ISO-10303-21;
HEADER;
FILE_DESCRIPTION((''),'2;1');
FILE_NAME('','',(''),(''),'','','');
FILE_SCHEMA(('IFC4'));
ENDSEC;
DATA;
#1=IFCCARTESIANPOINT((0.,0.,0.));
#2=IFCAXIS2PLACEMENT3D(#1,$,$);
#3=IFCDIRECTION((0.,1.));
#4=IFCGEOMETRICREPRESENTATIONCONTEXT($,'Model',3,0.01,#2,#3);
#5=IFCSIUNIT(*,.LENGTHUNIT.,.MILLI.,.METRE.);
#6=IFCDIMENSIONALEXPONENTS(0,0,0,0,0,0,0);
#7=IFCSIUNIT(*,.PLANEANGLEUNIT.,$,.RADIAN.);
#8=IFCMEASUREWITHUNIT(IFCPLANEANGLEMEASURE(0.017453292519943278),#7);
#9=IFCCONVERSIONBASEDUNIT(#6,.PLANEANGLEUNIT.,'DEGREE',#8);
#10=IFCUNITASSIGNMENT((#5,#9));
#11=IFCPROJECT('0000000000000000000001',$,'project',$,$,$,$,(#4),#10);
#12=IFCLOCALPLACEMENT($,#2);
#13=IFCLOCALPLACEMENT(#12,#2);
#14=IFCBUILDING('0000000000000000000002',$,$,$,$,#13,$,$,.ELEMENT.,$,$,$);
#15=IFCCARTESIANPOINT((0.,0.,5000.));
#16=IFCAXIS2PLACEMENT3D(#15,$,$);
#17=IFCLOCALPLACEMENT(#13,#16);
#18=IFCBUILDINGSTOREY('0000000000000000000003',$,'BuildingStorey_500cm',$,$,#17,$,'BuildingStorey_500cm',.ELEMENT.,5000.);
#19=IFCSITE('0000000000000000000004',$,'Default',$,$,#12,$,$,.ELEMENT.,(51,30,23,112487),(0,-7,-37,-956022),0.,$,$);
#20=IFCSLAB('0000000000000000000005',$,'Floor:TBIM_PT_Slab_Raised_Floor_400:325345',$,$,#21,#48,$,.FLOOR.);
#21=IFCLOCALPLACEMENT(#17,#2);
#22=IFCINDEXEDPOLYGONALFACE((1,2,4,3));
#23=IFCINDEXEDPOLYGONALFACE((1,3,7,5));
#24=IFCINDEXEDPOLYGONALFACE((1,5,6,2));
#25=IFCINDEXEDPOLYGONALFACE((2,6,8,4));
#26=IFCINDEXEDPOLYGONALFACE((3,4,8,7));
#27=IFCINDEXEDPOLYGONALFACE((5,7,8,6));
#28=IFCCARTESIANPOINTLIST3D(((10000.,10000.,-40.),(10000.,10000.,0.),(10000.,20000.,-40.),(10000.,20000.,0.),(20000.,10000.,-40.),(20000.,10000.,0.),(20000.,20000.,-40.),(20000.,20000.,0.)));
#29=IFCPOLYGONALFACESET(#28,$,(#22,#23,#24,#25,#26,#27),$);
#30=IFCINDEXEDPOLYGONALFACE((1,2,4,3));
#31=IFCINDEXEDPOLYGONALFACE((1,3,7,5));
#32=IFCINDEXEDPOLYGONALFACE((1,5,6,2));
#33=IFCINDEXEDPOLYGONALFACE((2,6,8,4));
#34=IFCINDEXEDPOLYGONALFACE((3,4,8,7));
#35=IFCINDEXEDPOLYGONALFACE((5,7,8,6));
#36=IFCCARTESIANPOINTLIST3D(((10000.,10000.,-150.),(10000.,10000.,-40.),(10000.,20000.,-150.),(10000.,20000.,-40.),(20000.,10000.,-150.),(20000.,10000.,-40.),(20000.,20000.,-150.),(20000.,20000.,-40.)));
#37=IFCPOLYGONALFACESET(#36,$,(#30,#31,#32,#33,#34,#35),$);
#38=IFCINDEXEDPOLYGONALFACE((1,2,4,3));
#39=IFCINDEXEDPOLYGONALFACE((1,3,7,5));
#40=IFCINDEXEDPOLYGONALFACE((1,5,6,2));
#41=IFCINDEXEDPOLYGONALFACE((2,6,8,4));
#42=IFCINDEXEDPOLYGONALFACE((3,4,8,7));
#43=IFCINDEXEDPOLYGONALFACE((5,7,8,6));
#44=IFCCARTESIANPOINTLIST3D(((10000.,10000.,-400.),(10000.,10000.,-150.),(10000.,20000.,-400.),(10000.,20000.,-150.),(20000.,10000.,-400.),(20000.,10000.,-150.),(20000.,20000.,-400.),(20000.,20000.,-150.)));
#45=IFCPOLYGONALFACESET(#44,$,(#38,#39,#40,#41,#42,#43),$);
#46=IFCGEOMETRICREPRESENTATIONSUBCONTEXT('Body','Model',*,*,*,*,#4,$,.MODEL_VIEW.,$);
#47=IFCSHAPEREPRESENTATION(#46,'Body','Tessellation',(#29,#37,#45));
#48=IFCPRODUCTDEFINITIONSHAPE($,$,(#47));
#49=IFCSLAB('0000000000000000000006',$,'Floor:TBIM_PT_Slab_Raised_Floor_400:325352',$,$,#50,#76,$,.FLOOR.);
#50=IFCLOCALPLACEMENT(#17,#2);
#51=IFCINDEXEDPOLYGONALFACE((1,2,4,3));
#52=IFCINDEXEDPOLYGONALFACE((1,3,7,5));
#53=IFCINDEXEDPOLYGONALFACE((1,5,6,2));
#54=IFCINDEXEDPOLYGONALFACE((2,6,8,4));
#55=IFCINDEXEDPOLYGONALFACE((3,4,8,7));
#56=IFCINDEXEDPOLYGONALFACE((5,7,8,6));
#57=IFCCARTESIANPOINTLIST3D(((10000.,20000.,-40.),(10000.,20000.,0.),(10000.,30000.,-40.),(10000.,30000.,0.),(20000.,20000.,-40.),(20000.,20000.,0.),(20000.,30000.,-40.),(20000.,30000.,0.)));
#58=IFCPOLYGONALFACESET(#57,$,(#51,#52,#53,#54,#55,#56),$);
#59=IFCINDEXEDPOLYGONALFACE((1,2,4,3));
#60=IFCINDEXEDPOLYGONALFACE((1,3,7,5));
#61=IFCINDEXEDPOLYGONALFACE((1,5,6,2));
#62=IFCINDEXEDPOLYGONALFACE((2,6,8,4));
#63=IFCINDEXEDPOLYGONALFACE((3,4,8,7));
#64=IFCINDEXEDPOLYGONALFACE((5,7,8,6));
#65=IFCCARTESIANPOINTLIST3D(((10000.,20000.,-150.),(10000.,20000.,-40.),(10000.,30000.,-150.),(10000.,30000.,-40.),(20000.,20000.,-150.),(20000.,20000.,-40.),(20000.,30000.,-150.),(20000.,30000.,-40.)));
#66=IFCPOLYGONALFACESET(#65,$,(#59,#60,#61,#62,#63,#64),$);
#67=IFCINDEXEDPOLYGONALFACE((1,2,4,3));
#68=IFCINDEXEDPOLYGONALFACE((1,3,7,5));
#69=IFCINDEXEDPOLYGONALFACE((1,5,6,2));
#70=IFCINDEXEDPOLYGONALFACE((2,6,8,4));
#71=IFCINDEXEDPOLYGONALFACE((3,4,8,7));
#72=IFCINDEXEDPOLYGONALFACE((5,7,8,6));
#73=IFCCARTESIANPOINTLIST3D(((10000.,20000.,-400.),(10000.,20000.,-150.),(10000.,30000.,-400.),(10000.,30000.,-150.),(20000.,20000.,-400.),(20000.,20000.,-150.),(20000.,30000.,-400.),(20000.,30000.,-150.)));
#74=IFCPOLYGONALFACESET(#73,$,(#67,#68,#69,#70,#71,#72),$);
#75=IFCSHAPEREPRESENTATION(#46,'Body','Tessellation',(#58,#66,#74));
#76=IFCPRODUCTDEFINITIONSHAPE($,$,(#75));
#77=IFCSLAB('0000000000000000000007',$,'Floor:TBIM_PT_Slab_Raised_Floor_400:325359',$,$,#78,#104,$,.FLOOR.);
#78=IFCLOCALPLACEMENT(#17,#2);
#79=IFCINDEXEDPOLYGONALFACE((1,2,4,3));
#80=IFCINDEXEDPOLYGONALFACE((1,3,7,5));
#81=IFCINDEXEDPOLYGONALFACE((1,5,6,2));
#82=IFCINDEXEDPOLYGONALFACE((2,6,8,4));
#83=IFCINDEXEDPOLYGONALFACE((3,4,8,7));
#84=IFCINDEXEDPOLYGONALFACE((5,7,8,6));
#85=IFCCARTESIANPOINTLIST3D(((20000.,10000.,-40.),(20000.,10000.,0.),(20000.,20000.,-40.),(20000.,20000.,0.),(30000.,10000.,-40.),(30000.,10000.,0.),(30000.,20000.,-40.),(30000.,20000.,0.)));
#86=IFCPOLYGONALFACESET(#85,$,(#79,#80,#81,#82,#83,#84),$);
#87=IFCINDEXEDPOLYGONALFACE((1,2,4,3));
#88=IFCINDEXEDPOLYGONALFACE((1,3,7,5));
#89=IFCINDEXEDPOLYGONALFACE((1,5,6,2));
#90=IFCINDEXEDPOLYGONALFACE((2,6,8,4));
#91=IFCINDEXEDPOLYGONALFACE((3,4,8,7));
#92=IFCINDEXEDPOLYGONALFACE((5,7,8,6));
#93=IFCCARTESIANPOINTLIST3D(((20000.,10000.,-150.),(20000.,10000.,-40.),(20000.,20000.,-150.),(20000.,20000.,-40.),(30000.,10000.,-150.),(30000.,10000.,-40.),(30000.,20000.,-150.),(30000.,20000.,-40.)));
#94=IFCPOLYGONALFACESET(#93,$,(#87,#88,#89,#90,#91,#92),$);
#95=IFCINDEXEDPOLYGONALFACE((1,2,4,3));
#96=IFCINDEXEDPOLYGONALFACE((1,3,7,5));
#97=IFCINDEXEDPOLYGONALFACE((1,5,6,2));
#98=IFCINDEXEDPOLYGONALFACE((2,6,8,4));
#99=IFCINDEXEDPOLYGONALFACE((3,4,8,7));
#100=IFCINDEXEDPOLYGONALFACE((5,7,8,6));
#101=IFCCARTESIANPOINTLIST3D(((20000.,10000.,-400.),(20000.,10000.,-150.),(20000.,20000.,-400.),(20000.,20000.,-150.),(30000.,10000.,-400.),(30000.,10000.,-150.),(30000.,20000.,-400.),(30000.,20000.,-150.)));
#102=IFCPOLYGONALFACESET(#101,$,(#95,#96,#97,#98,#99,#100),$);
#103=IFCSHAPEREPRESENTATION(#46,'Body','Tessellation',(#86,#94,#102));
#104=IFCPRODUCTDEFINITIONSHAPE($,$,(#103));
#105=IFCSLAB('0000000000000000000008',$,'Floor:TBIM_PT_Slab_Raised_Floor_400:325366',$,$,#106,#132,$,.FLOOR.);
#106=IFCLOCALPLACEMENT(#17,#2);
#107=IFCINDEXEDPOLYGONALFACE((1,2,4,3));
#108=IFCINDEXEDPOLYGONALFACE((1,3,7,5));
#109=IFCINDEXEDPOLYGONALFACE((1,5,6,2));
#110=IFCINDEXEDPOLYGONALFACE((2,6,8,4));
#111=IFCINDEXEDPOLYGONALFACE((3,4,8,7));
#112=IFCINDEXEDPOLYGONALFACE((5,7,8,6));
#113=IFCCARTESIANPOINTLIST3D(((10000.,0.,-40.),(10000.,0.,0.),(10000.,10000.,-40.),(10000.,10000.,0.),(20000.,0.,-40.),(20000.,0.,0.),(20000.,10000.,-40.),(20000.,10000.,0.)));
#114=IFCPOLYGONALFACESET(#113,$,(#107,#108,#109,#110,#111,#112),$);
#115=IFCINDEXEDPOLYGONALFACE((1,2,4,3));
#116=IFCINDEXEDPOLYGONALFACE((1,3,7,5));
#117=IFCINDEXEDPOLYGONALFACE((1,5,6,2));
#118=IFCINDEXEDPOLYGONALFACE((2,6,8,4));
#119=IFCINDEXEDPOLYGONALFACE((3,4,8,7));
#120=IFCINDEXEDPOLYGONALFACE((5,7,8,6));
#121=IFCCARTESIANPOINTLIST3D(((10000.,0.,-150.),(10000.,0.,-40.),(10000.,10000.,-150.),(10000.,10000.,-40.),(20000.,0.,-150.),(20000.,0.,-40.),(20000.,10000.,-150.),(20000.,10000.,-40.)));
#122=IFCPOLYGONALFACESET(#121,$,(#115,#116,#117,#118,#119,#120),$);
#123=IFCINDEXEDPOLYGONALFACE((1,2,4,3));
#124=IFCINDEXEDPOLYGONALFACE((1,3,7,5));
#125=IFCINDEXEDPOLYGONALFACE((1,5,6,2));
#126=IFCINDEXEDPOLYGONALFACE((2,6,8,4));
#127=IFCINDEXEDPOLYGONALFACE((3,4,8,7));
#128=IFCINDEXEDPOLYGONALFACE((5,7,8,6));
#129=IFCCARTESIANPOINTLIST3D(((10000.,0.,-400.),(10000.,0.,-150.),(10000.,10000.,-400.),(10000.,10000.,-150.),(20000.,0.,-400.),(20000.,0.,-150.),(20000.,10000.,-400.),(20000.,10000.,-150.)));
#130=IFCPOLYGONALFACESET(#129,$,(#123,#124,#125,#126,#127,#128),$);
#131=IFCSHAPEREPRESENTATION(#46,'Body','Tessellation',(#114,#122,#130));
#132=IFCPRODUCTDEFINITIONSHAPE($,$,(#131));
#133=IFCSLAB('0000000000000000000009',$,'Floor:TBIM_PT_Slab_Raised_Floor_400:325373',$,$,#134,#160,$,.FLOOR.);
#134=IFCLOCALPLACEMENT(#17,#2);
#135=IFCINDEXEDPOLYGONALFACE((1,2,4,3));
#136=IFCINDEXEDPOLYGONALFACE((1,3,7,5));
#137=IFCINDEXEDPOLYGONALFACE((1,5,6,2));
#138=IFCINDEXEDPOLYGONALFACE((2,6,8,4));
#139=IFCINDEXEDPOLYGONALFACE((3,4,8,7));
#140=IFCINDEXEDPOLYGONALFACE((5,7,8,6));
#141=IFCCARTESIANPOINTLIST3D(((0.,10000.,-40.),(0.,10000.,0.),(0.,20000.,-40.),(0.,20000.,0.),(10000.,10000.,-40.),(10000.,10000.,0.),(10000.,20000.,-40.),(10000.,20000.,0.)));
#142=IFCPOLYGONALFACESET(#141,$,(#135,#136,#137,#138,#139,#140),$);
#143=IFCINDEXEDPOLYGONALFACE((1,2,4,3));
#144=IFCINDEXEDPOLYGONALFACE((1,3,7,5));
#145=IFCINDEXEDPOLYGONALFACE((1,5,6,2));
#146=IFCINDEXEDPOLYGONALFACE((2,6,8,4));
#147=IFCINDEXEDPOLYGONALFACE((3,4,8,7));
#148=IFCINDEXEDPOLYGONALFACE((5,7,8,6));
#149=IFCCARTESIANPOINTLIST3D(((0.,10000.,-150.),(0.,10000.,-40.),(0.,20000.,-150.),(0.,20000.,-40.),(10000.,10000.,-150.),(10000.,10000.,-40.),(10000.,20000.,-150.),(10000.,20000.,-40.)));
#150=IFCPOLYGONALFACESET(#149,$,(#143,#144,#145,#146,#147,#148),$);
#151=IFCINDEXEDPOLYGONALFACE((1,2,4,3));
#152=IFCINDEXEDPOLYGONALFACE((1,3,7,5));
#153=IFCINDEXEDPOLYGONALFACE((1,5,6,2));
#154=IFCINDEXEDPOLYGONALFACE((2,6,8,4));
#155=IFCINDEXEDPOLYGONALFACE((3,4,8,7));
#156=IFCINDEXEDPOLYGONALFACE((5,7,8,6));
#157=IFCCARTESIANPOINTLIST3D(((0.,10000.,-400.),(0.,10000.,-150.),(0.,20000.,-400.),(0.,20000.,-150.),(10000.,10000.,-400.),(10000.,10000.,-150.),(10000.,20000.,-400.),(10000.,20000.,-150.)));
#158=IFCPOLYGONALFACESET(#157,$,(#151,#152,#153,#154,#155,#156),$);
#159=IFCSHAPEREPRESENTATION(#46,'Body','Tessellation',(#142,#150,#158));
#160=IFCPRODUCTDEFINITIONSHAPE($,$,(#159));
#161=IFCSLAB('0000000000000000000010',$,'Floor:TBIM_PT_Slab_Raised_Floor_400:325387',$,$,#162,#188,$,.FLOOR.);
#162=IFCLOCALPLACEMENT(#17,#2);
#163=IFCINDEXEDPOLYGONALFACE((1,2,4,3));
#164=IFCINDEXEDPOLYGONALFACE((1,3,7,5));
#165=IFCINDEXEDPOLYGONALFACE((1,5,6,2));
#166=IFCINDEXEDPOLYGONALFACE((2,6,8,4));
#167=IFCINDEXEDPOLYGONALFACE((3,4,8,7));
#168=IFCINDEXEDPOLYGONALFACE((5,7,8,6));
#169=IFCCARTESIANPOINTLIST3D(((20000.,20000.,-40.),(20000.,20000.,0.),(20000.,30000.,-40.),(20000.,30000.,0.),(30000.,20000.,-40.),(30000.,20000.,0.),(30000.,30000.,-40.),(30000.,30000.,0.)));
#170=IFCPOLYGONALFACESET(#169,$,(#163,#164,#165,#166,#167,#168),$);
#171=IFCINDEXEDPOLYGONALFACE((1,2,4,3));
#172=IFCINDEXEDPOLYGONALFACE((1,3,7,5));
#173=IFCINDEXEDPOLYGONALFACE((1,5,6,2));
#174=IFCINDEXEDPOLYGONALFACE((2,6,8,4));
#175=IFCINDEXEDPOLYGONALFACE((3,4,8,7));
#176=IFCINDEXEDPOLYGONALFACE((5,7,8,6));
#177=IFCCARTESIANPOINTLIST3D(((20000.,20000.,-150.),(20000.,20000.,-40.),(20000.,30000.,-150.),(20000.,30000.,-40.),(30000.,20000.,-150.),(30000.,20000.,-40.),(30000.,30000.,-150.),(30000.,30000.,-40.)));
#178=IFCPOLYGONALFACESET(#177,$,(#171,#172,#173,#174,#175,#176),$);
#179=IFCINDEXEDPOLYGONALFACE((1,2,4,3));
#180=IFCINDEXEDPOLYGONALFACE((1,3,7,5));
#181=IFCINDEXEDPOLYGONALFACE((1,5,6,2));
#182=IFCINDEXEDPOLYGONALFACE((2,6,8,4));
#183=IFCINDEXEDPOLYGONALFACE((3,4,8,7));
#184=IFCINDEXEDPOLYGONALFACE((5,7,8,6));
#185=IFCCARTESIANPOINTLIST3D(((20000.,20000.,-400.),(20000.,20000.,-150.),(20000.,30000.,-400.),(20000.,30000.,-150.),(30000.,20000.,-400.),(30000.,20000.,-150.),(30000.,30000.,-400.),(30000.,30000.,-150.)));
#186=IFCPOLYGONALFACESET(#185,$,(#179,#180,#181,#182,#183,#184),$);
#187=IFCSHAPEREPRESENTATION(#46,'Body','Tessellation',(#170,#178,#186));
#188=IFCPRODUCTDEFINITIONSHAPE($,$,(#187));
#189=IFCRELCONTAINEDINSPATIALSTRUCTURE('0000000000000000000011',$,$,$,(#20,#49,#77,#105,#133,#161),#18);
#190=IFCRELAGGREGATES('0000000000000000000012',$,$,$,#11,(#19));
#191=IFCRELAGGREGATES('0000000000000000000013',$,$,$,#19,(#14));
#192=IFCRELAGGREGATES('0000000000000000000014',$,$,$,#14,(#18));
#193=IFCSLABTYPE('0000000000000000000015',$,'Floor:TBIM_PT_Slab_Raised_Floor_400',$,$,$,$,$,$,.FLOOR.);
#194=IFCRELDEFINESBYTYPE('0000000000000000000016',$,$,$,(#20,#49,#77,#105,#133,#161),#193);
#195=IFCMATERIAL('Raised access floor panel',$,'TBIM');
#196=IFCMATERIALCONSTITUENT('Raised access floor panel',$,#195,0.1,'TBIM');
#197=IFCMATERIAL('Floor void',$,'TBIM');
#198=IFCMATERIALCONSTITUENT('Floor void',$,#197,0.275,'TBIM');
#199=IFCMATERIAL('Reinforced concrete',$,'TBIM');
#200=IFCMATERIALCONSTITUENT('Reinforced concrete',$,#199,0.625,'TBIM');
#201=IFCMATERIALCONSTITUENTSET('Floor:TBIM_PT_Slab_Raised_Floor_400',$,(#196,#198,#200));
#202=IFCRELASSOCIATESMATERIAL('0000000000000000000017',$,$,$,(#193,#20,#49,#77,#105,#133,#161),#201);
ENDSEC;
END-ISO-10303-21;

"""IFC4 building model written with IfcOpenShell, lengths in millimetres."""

from ifc_helpers import new_model, entity, si_unit, converted_unit, direction, frame, origin, place, context, subcontext, project, spatial, indexed_curve, outline, extrude, material, constituent, constituent_set, type_object, element, save


model = new_model("IFC4")

# Units and contexts
model_context = context("Model", 3, precision=0.01, world=origin(), true_north=direction((0.0, 1.0)))
body_context = subcontext(model_context, "Body", "Model", "MODEL_VIEW")
ifc_project = project(units=[si_unit("LENGTHUNIT", "METRE", prefix="MILLI"), converted_unit("PLANEANGLEUNIT", "DEGREE", entity("IfcPlaneAngleMeasure", 0.017453292519943278), si_unit("PLANEANGLEUNIT", "RADIAN"), dimensions=[0, 0, 0, 0, 0, 0, 0])], contexts=[model_context])

# Site, building, storey
site_placement = place(None, origin())
site = spatial("IfcSite", under=ifc_project, at=site_placement, Name="Default", CompositionType="ELEMENT", RefLatitude=(51, 30, 23, 112487), RefLongitude=(0, -7, -37, -956022), RefElevation=0.0)
building_placement = place(site_placement, origin())
building = spatial("IfcBuilding", under=site, at=building_placement, CompositionType="ELEMENT")
storey_placement = place(building_placement, frame((0.0, 0.0, 5000.0)))
storey = spatial("IfcBuildingStorey", under=building, at=storey_placement, Name="BuildingStorey_500cm", LongName="BuildingStorey_500cm", CompositionType="ELEMENT", Elevation=5000.0)

# Slabs
ifc_material_1 = material(Name="Raised access floor panel", Category="TBIM")
ifc_constituent_1 = constituent(ifc_material_1, Name="Raised access floor panel", Category="TBIM", fraction=0.1)
ifc_material_2 = material(Name="Floor void", Category="TBIM")
ifc_constituent_2 = constituent(ifc_material_2, Name="Floor void", Category="TBIM", fraction=0.275)
ifc_material_3 = material(Name="Reinforced concrete", Category="TBIM")
ifc_constituent_3 = constituent(ifc_material_3, Name="Reinforced concrete", Category="TBIM", fraction=0.625)
ifc_constituent_set_1 = constituent_set(constituents=[ifc_constituent_1, ifc_constituent_2, ifc_constituent_3], Name="Floor:TBIM_PT_Slab_Raised_Floor_400")
slab_type = type_object("IfcSlabType", Name="Floor:TBIM_PT_Slab_Raised_Floor_400", PredefinedType="FLOOR", material=ifc_constituent_set_1)
slab_1_placement = place(storey_placement, origin())
element("IfcSlab", 1, at=slab_1_placement, inside=storey, type_object=slab_type, material=ifc_constituent_set_1, Name="Floor:TBIM_PT_Slab_Raised_Floor_400:325345", PredefinedType="FLOOR", context=body_context, shape_type="SweptSolid", body=[
    extrude(outline(indexed_curve([(-5000.0, -5000.0), (5000.0, -5000.0), (5000.0, 5000.0), (-5000.0, 5000.0), (-5000.0, -5000.0)], self_intersect=False)), frame((15000.0, 15000.0, -40.0), z_axis=(0.0, 0.0, 1.0), x_axis=(-1.0, 0.0, 0.0)), (0.0, 0.0, 1.0), 40.0),
    extrude(outline(indexed_curve([(-5000.0, -5000.0), (5000.0, -5000.0), (5000.0, 5000.0), (-5000.0, 5000.0), (-5000.0, -5000.0)], self_intersect=False)), frame((15000.0, 15000.0, -150.0), z_axis=(0.0, 0.0, 1.0), x_axis=(-1.0, 0.0, 0.0)), (0.0, 0.0, 1.0), 110.0),
    extrude(outline(indexed_curve([(-5000.0, -5000.0), (5000.0, -5000.0), (5000.0, 5000.0), (-5000.0, 5000.0), (-5000.0, -5000.0)], self_intersect=False)), frame((15000.0, 15000.0, -400.0), z_axis=(0.0, 0.0, 1.0), x_axis=(-1.0, 0.0, 0.0)), (0.0, 0.0, 1.0), 250.0),
])
slab_2_placement = place(storey_placement, origin())
element("IfcSlab", 2, at=slab_2_placement, inside=storey, type_object=slab_type, material=ifc_constituent_set_1, Name="Floor:TBIM_PT_Slab_Raised_Floor_400:325352", PredefinedType="FLOOR", context=body_context, shape_type="SweptSolid", body=[
    extrude(outline(indexed_curve([(-5000.0, -5000.0), (5000.0, -5000.0), (5000.0, 5000.0), (-5000.0, 5000.0), (-5000.0, -5000.0)], self_intersect=False)), frame((15000.0, 25000.0, -40.0), z_axis=(0.0, 0.0, 1.0), x_axis=(-1.0, 0.0, 0.0)), (0.0, 0.0, 1.0), 40.0),
    extrude(outline(indexed_curve([(-5000.0, -5000.0), (5000.0, -5000.0), (5000.0, 5000.0), (-5000.0, 5000.0), (-5000.0, -5000.0)], self_intersect=False)), frame((15000.0, 25000.0, -150.0), z_axis=(0.0, 0.0, 1.0), x_axis=(-1.0, 0.0, 0.0)), (0.0, 0.0, 1.0), 110.0),
    extrude(outline(indexed_curve([(-5000.0, -5000.0), (5000.0, -5000.0), (5000.0, 5000.0), (-5000.0, 5000.0), (-5000.0, -5000.0)], self_intersect=False)), frame((15000.0, 25000.0, -400.0), z_axis=(0.0, 0.0, 1.0), x_axis=(-1.0, 0.0, 0.0)), (0.0, 0.0, 1.0), 250.0),
])
slab_3_placement = place(storey_placement, origin())
element("IfcSlab", 3, at=slab_3_placement, inside=storey, type_object=slab_type, material=ifc_constituent_set_1, Name="Floor:TBIM_PT_Slab_Raised_Floor_400:325359", PredefinedType="FLOOR", context=body_context, shape_type="SweptSolid", body=[
    extrude(outline(indexed_curve([(-5000.0, -5000.0), (5000.0, -5000.0), (5000.0, 5000.0), (-5000.0, 5000.0), (-5000.0, -5000.0)], self_intersect=False)), frame((25000.0, 15000.0, -40.0), z_axis=(0.0, 0.0, 1.0), x_axis=(-1.0, 0.0, 0.0)), (0.0, 0.0, 1.0), 40.0),
    extrude(outline(indexed_curve([(-5000.0, -5000.0), (5000.0, -5000.0), (5000.0, 5000.0), (-5000.0, 5000.0), (-5000.0, -5000.0)], self_intersect=False)), frame((25000.0, 15000.0, -150.0), z_axis=(0.0, 0.0, 1.0), x_axis=(-1.0, 0.0, 0.0)), (0.0, 0.0, 1.0), 110.0),
    extrude(outline(indexed_curve([(-5000.0, -5000.0), (5000.0, -5000.0), (5000.0, 5000.0), (-5000.0, 5000.0), (-5000.0, -5000.0)], self_intersect=False)), frame((25000.0, 15000.0, -400.0), z_axis=(0.0, 0.0, 1.0), x_axis=(-1.0, 0.0, 0.0)), (0.0, 0.0, 1.0), 250.0),
])
slab_4_placement = place(storey_placement, origin())
element("IfcSlab", 4, at=slab_4_placement, inside=storey, type_object=slab_type, material=ifc_constituent_set_1, Name="Floor:TBIM_PT_Slab_Raised_Floor_400:325366", PredefinedType="FLOOR", context=body_context, shape_type="SweptSolid", body=[
    extrude(outline(indexed_curve([(-5000.0, -5000.0), (5000.0, -5000.0), (5000.0, 5000.0), (-5000.0, 5000.0), (-5000.0, -5000.0)], self_intersect=False)), frame((15000.0, 5000.0, -40.0), z_axis=(0.0, 0.0, 1.0), x_axis=(0.0, 1.0, 0.0)), (0.0, 0.0, 1.0), 40.0),
    extrude(outline(indexed_curve([(-5000.0, -5000.0), (5000.0, -5000.0), (5000.0, 5000.0), (-5000.0, 5000.0), (-5000.0, -5000.0)], self_intersect=False)), frame((15000.0, 5000.0, -150.0), z_axis=(0.0, 0.0, 1.0), x_axis=(0.0, 1.0, 0.0)), (0.0, 0.0, 1.0), 110.0),
    extrude(outline(indexed_curve([(-5000.0, -5000.0), (5000.0, -5000.0), (5000.0, 5000.0), (-5000.0, 5000.0), (-5000.0, -5000.0)], self_intersect=False)), frame((15000.0, 5000.0, -400.0), z_axis=(0.0, 0.0, 1.0), x_axis=(0.0, 1.0, 0.0)), (0.0, 0.0, 1.0), 250.0),
])
slab_5_placement = place(storey_placement, origin())
element("IfcSlab", 5, at=slab_5_placement, inside=storey, type_object=slab_type, material=ifc_constituent_set_1, Name="Floor:TBIM_PT_Slab_Raised_Floor_400:325373", PredefinedType="FLOOR", context=body_context, shape_type="SweptSolid", body=[
    extrude(outline(indexed_curve([(-5000.0, -5000.0), (5000.0, -5000.0), (5000.0, 5000.0), (-5000.0, 5000.0), (-5000.0, -5000.0)], self_intersect=False)), frame((5000.0, 15000.0, -40.0), z_axis=(0.0, 0.0, 1.0), x_axis=(0.0, 1.0, 0.0)), (0.0, 0.0, 1.0), 40.0),
    extrude(outline(indexed_curve([(-5000.0, -5000.0), (5000.0, -5000.0), (5000.0, 5000.0), (-5000.0, 5000.0), (-5000.0, -5000.0)], self_intersect=False)), frame((5000.0, 15000.0, -150.0), z_axis=(0.0, 0.0, 1.0), x_axis=(0.0, 1.0, 0.0)), (0.0, 0.0, 1.0), 110.0),
    extrude(outline(indexed_curve([(-5000.0, -5000.0), (5000.0, -5000.0), (5000.0, 5000.0), (-5000.0, 5000.0), (-5000.0, -5000.0)], self_intersect=False)), frame((5000.0, 15000.0, -400.0), z_axis=(0.0, 0.0, 1.0), x_axis=(0.0, 1.0, 0.0)), (0.0, 0.0, 1.0), 250.0),
])
slab_6_placement = place(storey_placement, origin())
element("IfcSlab", 6, at=slab_6_placement, inside=storey, type_object=slab_type, material=ifc_constituent_set_1, Name="Floor:TBIM_PT_Slab_Raised_Floor_400:325387", PredefinedType="FLOOR", context=body_context, shape_type="SweptSolid", body=[
    extrude(outline(indexed_curve([(-5000.0, -5000.0), (5000.0, -5000.0), (5000.0, 5000.0), (-5000.0, 5000.0), (-5000.0, -5000.0)], self_intersect=False)), frame((25000.0, 25000.0, -40.0), z_axis=(0.0, 0.0, 1.0), x_axis=(-1.0, 0.0, 0.0)), (0.0, 0.0, 1.0), 40.0),
    extrude(outline(indexed_curve([(-5000.0, -5000.0), (5000.0, -5000.0), (5000.0, 5000.0), (-5000.0, 5000.0), (-5000.0, -5000.0)], self_intersect=False)), frame((25000.0, 25000.0, -150.0), z_axis=(0.0, 0.0, 1.0), x_axis=(-1.0, 0.0, 0.0)), (0.0, 0.0, 1.0), 110.0),
    extrude(outline(indexed_curve([(-5000.0, -5000.0), (5000.0, -5000.0), (5000.0, 5000.0), (-5000.0, 5000.0), (-5000.0, -5000.0)], self_intersect=False)), frame((25000.0, 25000.0, -400.0), z_axis=(0.0, 0.0, 1.0), x_axis=(-1.0, 0.0, 0.0)), (0.0, 0.0, 1.0), 250.0),
])

save(model, "model.ifc")
